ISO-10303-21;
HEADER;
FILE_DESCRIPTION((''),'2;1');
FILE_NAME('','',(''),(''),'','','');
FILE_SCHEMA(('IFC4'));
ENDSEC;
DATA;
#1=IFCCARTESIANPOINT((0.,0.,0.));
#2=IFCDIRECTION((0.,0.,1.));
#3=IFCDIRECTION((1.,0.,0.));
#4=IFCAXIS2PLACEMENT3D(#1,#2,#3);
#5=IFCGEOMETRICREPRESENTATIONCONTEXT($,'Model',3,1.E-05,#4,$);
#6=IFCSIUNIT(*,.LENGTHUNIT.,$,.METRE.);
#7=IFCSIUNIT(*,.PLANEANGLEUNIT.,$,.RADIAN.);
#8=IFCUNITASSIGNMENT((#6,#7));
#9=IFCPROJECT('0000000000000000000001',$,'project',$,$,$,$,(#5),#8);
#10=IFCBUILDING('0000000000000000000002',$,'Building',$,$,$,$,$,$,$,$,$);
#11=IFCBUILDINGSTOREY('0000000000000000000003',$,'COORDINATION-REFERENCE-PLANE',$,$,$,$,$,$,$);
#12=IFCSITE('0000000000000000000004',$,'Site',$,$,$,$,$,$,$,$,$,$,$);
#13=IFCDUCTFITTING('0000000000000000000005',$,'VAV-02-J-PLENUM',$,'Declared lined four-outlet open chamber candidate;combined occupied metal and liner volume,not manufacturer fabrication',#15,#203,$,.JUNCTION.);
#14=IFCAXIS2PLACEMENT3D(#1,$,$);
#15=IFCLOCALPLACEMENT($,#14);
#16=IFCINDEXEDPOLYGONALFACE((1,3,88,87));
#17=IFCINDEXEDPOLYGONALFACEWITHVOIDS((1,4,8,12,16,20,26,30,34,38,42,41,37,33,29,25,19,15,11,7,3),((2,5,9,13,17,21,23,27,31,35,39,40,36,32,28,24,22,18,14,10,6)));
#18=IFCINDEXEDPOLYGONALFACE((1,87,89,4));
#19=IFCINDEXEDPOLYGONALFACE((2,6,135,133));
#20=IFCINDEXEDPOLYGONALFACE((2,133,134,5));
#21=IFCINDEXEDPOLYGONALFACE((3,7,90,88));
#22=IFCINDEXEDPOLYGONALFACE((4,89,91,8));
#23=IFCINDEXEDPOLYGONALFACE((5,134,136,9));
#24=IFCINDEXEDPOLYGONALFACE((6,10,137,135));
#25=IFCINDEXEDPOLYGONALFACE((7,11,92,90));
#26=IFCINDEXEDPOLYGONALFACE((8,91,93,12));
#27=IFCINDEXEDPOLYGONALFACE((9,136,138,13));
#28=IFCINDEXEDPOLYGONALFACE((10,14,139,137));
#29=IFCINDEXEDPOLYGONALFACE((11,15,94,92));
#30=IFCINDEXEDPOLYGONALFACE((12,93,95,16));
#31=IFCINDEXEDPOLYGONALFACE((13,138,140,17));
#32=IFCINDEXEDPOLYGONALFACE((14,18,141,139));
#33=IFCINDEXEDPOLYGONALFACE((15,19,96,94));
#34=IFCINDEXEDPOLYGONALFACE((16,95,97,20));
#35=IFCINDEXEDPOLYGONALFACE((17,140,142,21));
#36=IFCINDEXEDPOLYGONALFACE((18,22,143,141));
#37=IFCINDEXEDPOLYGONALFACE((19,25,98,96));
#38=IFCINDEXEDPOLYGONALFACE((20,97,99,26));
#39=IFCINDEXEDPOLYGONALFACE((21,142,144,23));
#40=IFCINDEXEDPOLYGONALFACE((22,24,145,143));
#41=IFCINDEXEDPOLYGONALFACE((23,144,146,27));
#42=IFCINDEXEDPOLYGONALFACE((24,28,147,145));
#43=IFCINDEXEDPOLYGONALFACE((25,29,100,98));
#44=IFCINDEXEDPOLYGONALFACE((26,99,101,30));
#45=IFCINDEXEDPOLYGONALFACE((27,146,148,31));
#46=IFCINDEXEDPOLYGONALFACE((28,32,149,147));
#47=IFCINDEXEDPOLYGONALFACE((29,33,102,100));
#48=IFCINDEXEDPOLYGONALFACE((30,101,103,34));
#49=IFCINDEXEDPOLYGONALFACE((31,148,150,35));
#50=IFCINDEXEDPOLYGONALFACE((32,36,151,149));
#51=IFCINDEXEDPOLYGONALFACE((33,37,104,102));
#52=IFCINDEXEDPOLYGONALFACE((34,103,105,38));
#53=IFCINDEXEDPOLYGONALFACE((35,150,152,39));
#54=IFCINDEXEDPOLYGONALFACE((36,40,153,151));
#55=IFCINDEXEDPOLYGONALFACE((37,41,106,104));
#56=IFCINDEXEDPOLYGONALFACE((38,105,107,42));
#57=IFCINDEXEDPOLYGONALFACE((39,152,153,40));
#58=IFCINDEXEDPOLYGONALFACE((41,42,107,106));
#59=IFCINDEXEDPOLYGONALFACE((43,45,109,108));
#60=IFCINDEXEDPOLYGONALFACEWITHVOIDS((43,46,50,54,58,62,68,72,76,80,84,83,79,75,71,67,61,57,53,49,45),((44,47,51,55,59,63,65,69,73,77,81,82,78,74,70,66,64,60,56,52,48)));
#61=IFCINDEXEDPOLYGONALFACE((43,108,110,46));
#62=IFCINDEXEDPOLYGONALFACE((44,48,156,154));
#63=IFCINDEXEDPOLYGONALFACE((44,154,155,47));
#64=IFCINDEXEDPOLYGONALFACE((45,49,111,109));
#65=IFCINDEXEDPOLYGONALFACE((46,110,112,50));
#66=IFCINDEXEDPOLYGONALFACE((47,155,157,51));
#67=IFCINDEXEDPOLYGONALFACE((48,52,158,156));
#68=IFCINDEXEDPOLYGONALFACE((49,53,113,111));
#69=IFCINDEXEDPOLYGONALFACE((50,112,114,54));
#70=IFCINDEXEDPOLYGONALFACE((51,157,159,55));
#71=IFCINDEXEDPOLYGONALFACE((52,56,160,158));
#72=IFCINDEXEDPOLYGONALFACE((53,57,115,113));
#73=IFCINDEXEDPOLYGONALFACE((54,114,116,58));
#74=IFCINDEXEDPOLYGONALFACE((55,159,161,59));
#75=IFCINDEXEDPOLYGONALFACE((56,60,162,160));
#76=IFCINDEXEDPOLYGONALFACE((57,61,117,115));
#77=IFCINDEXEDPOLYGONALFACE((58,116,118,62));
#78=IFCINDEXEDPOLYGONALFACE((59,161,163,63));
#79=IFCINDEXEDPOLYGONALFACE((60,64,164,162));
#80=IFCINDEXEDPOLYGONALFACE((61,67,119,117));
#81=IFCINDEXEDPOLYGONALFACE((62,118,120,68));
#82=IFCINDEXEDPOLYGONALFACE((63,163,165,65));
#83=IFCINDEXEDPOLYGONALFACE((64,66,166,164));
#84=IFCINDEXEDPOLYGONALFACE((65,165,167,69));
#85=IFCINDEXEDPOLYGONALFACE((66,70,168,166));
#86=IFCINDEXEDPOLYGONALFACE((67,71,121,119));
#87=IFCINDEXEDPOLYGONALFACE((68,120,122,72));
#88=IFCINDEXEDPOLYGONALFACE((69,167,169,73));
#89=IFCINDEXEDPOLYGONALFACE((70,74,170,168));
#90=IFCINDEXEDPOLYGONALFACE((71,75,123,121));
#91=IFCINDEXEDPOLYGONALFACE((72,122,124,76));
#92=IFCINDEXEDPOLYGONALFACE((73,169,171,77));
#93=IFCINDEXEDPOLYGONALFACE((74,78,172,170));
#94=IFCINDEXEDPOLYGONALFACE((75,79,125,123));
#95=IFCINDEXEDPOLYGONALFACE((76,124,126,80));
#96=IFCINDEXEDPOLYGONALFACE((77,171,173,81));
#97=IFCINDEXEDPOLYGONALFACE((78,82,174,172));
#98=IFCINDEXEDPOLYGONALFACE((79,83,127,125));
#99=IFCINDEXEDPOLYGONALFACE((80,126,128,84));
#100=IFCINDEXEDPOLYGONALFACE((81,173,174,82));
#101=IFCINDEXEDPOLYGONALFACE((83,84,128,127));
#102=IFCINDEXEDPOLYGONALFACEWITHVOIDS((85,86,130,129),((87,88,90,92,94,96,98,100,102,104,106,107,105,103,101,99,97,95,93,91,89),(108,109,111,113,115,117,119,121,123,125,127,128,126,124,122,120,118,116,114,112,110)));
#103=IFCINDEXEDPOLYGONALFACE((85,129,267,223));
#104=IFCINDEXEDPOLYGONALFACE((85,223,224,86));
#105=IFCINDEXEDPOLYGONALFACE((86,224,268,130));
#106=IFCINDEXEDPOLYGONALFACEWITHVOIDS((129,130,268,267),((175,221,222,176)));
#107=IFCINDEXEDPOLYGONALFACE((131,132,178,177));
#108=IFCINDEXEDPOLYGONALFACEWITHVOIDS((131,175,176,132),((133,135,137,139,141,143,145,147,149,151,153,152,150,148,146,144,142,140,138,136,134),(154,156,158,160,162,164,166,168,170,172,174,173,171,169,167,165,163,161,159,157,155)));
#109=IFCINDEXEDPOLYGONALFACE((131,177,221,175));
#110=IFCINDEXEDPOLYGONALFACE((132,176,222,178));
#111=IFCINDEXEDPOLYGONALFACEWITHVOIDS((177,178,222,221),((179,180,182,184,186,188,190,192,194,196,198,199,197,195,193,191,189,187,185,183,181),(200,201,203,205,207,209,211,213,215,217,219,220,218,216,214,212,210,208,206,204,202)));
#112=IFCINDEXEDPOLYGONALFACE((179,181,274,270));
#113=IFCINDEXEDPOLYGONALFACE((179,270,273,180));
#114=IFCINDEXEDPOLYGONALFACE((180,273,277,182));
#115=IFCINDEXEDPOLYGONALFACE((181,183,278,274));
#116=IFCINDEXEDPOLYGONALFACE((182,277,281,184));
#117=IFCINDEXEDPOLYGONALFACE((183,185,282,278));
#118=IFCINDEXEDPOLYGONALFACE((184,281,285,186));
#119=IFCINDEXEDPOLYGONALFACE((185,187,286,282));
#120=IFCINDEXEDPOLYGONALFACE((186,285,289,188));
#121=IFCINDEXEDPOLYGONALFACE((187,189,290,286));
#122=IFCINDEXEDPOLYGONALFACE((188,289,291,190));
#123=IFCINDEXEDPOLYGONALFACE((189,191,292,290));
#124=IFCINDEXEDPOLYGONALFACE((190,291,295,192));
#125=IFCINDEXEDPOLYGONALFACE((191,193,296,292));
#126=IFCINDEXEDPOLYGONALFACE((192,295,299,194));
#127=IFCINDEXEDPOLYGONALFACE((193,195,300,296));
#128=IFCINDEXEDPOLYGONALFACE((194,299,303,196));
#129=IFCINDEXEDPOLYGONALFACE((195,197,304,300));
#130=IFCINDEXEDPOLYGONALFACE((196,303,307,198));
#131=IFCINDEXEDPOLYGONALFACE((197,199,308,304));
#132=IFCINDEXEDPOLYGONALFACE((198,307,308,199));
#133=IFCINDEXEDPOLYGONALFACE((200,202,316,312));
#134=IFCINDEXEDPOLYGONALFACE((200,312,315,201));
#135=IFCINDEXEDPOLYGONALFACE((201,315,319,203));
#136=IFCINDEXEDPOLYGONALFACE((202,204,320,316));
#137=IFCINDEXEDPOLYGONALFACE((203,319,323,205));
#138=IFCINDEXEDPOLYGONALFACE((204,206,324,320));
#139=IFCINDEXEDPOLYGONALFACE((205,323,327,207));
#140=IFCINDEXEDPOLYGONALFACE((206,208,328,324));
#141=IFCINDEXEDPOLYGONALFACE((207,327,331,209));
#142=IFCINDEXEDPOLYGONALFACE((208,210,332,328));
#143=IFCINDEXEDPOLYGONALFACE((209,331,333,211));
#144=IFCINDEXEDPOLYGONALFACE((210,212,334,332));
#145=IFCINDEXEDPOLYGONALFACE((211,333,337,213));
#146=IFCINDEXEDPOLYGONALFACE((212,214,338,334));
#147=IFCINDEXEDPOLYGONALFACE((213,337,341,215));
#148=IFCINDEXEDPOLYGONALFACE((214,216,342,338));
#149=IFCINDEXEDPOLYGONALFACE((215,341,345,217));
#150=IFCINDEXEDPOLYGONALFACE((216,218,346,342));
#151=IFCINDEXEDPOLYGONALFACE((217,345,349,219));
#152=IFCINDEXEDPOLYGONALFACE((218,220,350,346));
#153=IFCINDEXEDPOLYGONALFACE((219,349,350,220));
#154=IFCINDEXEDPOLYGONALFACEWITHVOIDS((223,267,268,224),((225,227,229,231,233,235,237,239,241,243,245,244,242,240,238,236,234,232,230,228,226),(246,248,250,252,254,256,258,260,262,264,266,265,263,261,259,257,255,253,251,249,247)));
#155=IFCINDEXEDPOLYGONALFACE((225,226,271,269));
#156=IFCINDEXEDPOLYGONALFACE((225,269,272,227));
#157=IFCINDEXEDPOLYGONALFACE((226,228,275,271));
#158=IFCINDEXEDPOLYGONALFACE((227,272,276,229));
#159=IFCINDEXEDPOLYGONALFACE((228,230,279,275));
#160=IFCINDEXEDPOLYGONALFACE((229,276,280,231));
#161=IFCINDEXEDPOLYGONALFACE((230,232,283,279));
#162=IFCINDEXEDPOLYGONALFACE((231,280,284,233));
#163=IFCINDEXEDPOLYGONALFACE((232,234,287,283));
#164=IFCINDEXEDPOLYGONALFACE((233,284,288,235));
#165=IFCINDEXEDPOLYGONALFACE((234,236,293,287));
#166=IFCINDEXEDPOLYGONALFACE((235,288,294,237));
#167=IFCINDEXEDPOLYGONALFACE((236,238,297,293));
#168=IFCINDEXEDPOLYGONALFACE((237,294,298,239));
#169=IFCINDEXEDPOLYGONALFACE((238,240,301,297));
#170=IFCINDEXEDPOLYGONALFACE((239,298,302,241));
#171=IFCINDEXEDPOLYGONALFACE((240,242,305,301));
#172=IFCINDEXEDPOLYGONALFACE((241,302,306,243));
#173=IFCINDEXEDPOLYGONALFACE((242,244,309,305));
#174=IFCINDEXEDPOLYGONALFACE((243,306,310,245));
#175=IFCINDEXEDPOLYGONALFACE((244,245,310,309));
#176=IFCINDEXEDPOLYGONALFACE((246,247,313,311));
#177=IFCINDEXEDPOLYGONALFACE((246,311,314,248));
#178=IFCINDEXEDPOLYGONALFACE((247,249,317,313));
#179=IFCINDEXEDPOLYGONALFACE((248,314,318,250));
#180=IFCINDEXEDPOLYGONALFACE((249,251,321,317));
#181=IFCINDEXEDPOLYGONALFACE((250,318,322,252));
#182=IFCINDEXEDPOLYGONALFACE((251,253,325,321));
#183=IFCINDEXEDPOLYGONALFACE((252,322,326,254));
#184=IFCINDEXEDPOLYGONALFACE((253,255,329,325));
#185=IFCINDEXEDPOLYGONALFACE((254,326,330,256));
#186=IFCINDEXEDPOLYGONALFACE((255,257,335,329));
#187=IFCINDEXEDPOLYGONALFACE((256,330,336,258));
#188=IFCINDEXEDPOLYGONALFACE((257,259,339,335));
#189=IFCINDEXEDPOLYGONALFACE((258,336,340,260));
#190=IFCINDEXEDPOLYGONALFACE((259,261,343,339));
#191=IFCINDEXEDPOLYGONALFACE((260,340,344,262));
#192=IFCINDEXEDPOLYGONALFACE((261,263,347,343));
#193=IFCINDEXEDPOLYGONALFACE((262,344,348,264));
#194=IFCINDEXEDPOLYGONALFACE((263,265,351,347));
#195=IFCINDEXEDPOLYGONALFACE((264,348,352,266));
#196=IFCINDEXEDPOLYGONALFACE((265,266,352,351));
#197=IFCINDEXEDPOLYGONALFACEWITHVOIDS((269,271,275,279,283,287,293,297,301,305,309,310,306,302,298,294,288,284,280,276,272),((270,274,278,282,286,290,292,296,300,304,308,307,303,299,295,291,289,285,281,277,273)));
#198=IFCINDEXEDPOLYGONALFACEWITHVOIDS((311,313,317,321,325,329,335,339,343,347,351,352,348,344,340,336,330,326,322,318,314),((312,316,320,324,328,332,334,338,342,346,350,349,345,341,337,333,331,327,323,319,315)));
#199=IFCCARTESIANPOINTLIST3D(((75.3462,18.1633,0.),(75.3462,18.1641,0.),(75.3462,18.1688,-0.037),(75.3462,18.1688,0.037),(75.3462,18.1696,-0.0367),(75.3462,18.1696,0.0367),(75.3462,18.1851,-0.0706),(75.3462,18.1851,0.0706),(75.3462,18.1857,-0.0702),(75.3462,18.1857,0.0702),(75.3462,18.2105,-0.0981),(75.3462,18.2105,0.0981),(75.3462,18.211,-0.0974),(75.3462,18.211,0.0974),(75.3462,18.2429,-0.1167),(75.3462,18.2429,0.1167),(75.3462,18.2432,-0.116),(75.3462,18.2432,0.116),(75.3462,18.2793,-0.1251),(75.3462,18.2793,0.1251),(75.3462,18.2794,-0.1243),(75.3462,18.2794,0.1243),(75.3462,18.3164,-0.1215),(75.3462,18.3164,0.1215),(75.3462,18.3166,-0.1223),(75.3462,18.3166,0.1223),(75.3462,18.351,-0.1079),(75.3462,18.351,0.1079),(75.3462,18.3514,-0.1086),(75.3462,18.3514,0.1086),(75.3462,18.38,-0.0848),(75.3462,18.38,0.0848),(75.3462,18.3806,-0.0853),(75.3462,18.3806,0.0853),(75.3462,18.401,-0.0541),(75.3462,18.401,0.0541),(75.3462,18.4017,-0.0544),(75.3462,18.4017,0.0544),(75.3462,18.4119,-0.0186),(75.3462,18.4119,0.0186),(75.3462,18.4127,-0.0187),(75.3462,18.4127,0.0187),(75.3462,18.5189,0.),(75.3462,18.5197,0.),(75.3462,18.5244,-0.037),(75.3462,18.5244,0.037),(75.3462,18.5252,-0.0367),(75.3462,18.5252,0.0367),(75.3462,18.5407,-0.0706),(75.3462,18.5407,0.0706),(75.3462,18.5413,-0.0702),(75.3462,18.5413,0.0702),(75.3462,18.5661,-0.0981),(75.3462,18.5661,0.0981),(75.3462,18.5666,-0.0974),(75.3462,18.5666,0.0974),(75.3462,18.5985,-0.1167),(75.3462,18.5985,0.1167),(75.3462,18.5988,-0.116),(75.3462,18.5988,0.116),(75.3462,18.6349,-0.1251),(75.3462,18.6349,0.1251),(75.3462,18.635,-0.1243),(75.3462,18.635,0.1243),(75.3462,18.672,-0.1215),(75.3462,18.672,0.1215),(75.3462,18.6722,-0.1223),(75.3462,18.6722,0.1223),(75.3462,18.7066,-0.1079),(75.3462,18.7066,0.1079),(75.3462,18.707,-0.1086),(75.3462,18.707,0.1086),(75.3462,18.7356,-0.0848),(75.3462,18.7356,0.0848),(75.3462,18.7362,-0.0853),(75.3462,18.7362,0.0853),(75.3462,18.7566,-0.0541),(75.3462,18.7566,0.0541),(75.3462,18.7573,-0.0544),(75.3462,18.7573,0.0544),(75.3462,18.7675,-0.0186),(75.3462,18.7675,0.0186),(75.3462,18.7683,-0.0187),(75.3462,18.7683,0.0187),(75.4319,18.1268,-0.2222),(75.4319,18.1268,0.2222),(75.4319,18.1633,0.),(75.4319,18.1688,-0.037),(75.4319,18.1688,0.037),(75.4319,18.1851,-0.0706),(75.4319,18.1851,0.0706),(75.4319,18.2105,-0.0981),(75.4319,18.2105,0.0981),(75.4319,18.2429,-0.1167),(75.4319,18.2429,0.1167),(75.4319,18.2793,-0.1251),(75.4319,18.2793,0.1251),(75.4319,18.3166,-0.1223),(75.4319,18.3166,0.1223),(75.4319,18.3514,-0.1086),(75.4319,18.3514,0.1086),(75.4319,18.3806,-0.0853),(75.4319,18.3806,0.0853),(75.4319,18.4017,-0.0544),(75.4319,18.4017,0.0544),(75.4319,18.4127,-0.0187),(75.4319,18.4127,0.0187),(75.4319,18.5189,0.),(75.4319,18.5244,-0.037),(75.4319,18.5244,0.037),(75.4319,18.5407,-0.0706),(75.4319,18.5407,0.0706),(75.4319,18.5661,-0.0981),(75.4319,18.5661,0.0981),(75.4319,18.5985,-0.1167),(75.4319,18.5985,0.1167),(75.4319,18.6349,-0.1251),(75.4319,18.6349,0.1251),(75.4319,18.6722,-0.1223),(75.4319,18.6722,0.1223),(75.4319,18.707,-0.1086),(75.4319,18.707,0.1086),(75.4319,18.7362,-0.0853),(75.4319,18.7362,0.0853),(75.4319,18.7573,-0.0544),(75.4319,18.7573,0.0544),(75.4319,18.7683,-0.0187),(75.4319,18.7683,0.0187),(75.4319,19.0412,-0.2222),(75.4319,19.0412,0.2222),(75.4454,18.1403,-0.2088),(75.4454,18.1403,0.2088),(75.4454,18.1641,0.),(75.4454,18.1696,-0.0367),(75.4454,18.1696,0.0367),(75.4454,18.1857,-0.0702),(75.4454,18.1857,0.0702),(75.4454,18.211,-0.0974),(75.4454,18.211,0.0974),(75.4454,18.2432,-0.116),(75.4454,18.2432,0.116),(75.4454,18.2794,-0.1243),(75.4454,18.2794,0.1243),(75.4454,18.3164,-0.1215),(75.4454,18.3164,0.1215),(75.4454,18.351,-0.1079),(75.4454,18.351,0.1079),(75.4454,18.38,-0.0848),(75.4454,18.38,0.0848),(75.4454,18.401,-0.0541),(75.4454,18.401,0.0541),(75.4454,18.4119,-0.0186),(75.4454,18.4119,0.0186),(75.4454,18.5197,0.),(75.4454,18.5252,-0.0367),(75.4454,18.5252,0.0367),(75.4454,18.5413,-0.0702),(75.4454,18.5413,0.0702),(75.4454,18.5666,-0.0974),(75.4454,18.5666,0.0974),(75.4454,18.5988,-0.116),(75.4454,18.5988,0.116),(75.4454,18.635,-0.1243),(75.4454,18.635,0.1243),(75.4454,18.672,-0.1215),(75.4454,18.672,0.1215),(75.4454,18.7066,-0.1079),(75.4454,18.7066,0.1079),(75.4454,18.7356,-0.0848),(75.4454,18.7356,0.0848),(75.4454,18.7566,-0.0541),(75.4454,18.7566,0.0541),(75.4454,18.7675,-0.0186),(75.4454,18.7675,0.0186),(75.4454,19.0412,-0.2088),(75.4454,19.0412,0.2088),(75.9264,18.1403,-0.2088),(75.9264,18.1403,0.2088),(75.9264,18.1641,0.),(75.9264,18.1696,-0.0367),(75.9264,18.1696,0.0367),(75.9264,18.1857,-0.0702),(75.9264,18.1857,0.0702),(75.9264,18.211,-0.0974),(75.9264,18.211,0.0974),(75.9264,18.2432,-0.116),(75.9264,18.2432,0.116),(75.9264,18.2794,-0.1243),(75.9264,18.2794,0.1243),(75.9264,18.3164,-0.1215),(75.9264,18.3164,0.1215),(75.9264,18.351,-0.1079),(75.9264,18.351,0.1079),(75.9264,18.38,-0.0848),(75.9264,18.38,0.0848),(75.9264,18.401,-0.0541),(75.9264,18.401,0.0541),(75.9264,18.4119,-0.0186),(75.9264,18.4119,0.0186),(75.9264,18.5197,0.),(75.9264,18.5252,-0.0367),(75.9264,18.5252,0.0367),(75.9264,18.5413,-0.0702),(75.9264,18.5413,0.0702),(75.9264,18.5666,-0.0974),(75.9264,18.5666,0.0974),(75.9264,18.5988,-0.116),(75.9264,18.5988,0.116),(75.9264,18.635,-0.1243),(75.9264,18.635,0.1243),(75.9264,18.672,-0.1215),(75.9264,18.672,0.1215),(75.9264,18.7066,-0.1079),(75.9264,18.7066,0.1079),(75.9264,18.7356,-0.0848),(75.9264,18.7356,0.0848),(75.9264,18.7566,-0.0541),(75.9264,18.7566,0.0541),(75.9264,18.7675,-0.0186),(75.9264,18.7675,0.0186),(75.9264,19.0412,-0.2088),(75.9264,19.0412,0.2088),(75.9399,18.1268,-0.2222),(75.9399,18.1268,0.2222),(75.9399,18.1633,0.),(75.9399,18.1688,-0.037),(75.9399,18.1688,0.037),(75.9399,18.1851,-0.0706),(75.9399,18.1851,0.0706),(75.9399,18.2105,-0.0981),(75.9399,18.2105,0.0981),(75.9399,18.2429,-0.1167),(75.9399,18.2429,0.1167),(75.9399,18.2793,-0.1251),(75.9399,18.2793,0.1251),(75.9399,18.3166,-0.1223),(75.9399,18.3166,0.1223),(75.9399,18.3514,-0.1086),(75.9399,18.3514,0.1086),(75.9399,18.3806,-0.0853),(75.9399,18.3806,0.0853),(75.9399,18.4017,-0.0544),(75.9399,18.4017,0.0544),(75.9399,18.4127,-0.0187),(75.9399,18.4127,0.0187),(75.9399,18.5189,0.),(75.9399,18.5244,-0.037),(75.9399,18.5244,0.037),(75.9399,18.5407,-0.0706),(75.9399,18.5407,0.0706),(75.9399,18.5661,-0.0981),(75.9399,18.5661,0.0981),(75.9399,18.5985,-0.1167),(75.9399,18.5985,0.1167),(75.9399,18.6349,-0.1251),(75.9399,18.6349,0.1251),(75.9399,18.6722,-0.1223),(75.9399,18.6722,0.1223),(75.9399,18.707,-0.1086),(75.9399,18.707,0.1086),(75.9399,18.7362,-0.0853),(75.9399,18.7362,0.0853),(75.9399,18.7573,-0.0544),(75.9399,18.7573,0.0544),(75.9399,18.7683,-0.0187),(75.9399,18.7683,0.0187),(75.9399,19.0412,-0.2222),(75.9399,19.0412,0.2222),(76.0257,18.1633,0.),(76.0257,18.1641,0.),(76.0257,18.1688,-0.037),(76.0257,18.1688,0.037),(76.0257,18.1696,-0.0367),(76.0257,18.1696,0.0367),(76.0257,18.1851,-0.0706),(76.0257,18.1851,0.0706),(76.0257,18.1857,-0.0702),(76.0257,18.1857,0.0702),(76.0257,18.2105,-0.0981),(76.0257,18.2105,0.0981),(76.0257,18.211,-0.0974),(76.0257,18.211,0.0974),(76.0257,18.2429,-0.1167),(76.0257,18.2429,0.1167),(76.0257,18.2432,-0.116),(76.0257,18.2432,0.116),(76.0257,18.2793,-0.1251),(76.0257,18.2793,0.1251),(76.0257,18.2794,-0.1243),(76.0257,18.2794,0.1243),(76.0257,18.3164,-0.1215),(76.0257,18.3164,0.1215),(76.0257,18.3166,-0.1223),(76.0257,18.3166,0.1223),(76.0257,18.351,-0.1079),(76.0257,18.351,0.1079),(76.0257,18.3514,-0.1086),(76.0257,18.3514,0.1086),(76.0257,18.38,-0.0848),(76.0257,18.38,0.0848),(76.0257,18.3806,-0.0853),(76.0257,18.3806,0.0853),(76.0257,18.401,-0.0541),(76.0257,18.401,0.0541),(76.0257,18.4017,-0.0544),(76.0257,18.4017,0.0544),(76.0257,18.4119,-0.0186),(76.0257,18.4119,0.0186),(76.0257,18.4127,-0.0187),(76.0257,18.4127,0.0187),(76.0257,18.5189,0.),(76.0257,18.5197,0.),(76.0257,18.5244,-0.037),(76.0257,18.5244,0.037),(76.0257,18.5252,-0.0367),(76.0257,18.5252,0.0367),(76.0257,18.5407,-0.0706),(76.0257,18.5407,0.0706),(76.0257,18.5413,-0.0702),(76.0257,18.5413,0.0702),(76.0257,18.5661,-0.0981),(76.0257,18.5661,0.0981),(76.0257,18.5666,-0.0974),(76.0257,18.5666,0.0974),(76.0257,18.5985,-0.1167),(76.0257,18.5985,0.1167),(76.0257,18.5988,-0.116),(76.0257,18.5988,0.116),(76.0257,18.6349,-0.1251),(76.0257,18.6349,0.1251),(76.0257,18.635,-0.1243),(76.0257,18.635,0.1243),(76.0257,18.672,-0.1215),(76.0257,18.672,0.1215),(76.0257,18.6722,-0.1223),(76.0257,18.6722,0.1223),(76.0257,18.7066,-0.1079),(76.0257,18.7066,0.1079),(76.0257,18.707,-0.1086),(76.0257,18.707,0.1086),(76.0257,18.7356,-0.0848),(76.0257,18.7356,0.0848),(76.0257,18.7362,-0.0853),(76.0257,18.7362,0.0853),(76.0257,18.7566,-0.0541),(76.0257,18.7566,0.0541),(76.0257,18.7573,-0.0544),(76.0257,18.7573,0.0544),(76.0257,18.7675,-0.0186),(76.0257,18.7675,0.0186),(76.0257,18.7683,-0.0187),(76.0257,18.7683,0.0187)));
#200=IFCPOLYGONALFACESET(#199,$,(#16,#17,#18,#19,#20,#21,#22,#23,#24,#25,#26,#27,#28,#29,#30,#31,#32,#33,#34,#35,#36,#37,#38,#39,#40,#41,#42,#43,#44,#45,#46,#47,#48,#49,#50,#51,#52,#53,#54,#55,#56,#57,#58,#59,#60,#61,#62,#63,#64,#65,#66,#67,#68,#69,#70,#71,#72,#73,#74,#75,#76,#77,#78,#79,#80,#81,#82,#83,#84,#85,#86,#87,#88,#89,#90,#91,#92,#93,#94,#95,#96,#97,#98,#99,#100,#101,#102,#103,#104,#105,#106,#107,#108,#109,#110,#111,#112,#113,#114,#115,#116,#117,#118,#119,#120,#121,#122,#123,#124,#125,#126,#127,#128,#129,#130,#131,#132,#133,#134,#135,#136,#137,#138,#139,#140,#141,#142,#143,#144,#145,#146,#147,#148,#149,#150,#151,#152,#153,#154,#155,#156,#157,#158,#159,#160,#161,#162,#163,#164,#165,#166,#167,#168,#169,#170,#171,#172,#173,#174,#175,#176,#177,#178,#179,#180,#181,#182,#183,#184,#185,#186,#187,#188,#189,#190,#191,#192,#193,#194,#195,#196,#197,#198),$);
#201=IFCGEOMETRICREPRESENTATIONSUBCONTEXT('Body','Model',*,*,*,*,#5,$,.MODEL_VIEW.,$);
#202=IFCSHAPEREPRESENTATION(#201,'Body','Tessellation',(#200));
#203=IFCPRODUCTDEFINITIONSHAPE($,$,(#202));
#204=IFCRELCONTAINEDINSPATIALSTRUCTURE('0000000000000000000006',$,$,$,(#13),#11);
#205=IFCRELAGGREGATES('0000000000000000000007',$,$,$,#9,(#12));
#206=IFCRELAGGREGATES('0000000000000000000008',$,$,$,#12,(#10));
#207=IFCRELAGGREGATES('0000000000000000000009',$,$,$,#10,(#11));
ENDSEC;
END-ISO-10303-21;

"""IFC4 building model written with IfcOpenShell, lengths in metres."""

from ifc_helpers import new_model, si_unit, frame, origin_with_axes, place, context, subcontext, project, spatial, rectangle, circle, extrude, boolean, element, save


model = new_model("IFC4")

# Units and contexts
model_context = context("Model", 3, precision=1e-05, world=origin_with_axes())
body_context_1 = subcontext(model_context, "Body", "Model", "MODEL_VIEW")
ifc_project = project(units=[si_unit("LENGTHUNIT", "METRE"), si_unit("PLANEANGLEUNIT", "RADIAN")], contexts=[model_context])

# Site, building, storey
site = spatial("IfcSite", under=ifc_project, Name="Site")
building = spatial("IfcBuilding", under=site, Name="Building")
storey = spatial("IfcBuildingStorey", under=building, Name="COORDINATION-REFERENCE-PLANE")

# Duct fitting
duct_fitting_1_placement = place(None, frame((75.4319, 18.1268, -0.2223), z_axis=(0.0, 0.0, 1.0), x_axis=(1.0, 0.0, 0.0)))
solid_1 = boolean("UNION", boolean("UNION", boolean("UNION", boolean("UNION", extrude(rectangle(XDim=0.481, YDim=0.4175), frame((0.254, 0.9244, 0.2223), z_axis=(0.0, -1.0, 0.0), x_axis=(1.0, 0.0, 0.0)), (0.0, 0.0, 1.0), 0.9109), extrude(circle(Radius=0.1246), frame((0.0235, 0.5175, 0.2223), z_axis=(-1.0, 0.0, 0.0), x_axis=(0.0, -1.0, 0.0)), (0.0, 0.0, 1.0), 0.1192)), extrude(circle(Radius=0.1246), frame((0.4845, 0.5175, 0.2223), z_axis=(1.0, 0.0, 0.0), x_axis=(0.0, -1.0, 0.0)), (0.0, 0.0, 1.0), 0.1192)), extrude(circle(Radius=0.1246), frame((0.0235, 0.1619, 0.2223), z_axis=(-1.0, 0.0, 0.0), x_axis=(0.0, -1.0, 0.0)), (0.0, 0.0, 1.0), 0.1192)), extrude(circle(Radius=0.1246), frame((0.4845, 0.1619, 0.2223), z_axis=(1.0, 0.0, 0.0), x_axis=(0.0, -1.0, 0.0)), (0.0, 0.0, 1.0), 0.1192))
element("IfcDuctFitting", 1, at=duct_fitting_1_placement, inside=storey, Name="VAV-02-J-PLENUM", ObjectType="Declared lined four-outlet open chamber candidate;combined occupied metal and liner volume,not manufacturer fabrication", PredefinedType="JUNCTION", context=body_context_1, shape_type="CSG", body=[
    boolean("DIFFERENCE", boolean("UNION", boolean("UNION", boolean("UNION", boolean("UNION", extrude(rectangle(XDim=0.508, YDim=0.4445), frame((0.254, 0.9144, 0.2223), z_axis=(0.0, -1.0, 0.0), x_axis=(1.0, 0.0, 0.0)), (0.0, 0.0, 1.0), 0.9144), extrude(circle(Radius=0.1254), frame((0.0235, 0.5175, 0.2223), z_axis=(-1.0, 0.0, 0.0), x_axis=(0.0, -1.0, 0.0)), (0.0, 0.0, 1.0), 0.1092)), extrude(circle(Radius=0.1254), frame((0.4845, 0.5175, 0.2223), z_axis=(1.0, 0.0, 0.0), x_axis=(0.0, -1.0, 0.0)), (0.0, 0.0, 1.0), 0.1092)), extrude(circle(Radius=0.1254), frame((0.0235, 0.1619, 0.2223), z_axis=(-1.0, 0.0, 0.0), x_axis=(0.0, -1.0, 0.0)), (0.0, 0.0, 1.0), 0.1092)), extrude(circle(Radius=0.1254), frame((0.4845, 0.1619, 0.2223), z_axis=(1.0, 0.0, 0.0), x_axis=(0.0, -1.0, 0.0)), (0.0, 0.0, 1.0), 0.1092)), solid_1),
])

save(model, "model.ifc")
